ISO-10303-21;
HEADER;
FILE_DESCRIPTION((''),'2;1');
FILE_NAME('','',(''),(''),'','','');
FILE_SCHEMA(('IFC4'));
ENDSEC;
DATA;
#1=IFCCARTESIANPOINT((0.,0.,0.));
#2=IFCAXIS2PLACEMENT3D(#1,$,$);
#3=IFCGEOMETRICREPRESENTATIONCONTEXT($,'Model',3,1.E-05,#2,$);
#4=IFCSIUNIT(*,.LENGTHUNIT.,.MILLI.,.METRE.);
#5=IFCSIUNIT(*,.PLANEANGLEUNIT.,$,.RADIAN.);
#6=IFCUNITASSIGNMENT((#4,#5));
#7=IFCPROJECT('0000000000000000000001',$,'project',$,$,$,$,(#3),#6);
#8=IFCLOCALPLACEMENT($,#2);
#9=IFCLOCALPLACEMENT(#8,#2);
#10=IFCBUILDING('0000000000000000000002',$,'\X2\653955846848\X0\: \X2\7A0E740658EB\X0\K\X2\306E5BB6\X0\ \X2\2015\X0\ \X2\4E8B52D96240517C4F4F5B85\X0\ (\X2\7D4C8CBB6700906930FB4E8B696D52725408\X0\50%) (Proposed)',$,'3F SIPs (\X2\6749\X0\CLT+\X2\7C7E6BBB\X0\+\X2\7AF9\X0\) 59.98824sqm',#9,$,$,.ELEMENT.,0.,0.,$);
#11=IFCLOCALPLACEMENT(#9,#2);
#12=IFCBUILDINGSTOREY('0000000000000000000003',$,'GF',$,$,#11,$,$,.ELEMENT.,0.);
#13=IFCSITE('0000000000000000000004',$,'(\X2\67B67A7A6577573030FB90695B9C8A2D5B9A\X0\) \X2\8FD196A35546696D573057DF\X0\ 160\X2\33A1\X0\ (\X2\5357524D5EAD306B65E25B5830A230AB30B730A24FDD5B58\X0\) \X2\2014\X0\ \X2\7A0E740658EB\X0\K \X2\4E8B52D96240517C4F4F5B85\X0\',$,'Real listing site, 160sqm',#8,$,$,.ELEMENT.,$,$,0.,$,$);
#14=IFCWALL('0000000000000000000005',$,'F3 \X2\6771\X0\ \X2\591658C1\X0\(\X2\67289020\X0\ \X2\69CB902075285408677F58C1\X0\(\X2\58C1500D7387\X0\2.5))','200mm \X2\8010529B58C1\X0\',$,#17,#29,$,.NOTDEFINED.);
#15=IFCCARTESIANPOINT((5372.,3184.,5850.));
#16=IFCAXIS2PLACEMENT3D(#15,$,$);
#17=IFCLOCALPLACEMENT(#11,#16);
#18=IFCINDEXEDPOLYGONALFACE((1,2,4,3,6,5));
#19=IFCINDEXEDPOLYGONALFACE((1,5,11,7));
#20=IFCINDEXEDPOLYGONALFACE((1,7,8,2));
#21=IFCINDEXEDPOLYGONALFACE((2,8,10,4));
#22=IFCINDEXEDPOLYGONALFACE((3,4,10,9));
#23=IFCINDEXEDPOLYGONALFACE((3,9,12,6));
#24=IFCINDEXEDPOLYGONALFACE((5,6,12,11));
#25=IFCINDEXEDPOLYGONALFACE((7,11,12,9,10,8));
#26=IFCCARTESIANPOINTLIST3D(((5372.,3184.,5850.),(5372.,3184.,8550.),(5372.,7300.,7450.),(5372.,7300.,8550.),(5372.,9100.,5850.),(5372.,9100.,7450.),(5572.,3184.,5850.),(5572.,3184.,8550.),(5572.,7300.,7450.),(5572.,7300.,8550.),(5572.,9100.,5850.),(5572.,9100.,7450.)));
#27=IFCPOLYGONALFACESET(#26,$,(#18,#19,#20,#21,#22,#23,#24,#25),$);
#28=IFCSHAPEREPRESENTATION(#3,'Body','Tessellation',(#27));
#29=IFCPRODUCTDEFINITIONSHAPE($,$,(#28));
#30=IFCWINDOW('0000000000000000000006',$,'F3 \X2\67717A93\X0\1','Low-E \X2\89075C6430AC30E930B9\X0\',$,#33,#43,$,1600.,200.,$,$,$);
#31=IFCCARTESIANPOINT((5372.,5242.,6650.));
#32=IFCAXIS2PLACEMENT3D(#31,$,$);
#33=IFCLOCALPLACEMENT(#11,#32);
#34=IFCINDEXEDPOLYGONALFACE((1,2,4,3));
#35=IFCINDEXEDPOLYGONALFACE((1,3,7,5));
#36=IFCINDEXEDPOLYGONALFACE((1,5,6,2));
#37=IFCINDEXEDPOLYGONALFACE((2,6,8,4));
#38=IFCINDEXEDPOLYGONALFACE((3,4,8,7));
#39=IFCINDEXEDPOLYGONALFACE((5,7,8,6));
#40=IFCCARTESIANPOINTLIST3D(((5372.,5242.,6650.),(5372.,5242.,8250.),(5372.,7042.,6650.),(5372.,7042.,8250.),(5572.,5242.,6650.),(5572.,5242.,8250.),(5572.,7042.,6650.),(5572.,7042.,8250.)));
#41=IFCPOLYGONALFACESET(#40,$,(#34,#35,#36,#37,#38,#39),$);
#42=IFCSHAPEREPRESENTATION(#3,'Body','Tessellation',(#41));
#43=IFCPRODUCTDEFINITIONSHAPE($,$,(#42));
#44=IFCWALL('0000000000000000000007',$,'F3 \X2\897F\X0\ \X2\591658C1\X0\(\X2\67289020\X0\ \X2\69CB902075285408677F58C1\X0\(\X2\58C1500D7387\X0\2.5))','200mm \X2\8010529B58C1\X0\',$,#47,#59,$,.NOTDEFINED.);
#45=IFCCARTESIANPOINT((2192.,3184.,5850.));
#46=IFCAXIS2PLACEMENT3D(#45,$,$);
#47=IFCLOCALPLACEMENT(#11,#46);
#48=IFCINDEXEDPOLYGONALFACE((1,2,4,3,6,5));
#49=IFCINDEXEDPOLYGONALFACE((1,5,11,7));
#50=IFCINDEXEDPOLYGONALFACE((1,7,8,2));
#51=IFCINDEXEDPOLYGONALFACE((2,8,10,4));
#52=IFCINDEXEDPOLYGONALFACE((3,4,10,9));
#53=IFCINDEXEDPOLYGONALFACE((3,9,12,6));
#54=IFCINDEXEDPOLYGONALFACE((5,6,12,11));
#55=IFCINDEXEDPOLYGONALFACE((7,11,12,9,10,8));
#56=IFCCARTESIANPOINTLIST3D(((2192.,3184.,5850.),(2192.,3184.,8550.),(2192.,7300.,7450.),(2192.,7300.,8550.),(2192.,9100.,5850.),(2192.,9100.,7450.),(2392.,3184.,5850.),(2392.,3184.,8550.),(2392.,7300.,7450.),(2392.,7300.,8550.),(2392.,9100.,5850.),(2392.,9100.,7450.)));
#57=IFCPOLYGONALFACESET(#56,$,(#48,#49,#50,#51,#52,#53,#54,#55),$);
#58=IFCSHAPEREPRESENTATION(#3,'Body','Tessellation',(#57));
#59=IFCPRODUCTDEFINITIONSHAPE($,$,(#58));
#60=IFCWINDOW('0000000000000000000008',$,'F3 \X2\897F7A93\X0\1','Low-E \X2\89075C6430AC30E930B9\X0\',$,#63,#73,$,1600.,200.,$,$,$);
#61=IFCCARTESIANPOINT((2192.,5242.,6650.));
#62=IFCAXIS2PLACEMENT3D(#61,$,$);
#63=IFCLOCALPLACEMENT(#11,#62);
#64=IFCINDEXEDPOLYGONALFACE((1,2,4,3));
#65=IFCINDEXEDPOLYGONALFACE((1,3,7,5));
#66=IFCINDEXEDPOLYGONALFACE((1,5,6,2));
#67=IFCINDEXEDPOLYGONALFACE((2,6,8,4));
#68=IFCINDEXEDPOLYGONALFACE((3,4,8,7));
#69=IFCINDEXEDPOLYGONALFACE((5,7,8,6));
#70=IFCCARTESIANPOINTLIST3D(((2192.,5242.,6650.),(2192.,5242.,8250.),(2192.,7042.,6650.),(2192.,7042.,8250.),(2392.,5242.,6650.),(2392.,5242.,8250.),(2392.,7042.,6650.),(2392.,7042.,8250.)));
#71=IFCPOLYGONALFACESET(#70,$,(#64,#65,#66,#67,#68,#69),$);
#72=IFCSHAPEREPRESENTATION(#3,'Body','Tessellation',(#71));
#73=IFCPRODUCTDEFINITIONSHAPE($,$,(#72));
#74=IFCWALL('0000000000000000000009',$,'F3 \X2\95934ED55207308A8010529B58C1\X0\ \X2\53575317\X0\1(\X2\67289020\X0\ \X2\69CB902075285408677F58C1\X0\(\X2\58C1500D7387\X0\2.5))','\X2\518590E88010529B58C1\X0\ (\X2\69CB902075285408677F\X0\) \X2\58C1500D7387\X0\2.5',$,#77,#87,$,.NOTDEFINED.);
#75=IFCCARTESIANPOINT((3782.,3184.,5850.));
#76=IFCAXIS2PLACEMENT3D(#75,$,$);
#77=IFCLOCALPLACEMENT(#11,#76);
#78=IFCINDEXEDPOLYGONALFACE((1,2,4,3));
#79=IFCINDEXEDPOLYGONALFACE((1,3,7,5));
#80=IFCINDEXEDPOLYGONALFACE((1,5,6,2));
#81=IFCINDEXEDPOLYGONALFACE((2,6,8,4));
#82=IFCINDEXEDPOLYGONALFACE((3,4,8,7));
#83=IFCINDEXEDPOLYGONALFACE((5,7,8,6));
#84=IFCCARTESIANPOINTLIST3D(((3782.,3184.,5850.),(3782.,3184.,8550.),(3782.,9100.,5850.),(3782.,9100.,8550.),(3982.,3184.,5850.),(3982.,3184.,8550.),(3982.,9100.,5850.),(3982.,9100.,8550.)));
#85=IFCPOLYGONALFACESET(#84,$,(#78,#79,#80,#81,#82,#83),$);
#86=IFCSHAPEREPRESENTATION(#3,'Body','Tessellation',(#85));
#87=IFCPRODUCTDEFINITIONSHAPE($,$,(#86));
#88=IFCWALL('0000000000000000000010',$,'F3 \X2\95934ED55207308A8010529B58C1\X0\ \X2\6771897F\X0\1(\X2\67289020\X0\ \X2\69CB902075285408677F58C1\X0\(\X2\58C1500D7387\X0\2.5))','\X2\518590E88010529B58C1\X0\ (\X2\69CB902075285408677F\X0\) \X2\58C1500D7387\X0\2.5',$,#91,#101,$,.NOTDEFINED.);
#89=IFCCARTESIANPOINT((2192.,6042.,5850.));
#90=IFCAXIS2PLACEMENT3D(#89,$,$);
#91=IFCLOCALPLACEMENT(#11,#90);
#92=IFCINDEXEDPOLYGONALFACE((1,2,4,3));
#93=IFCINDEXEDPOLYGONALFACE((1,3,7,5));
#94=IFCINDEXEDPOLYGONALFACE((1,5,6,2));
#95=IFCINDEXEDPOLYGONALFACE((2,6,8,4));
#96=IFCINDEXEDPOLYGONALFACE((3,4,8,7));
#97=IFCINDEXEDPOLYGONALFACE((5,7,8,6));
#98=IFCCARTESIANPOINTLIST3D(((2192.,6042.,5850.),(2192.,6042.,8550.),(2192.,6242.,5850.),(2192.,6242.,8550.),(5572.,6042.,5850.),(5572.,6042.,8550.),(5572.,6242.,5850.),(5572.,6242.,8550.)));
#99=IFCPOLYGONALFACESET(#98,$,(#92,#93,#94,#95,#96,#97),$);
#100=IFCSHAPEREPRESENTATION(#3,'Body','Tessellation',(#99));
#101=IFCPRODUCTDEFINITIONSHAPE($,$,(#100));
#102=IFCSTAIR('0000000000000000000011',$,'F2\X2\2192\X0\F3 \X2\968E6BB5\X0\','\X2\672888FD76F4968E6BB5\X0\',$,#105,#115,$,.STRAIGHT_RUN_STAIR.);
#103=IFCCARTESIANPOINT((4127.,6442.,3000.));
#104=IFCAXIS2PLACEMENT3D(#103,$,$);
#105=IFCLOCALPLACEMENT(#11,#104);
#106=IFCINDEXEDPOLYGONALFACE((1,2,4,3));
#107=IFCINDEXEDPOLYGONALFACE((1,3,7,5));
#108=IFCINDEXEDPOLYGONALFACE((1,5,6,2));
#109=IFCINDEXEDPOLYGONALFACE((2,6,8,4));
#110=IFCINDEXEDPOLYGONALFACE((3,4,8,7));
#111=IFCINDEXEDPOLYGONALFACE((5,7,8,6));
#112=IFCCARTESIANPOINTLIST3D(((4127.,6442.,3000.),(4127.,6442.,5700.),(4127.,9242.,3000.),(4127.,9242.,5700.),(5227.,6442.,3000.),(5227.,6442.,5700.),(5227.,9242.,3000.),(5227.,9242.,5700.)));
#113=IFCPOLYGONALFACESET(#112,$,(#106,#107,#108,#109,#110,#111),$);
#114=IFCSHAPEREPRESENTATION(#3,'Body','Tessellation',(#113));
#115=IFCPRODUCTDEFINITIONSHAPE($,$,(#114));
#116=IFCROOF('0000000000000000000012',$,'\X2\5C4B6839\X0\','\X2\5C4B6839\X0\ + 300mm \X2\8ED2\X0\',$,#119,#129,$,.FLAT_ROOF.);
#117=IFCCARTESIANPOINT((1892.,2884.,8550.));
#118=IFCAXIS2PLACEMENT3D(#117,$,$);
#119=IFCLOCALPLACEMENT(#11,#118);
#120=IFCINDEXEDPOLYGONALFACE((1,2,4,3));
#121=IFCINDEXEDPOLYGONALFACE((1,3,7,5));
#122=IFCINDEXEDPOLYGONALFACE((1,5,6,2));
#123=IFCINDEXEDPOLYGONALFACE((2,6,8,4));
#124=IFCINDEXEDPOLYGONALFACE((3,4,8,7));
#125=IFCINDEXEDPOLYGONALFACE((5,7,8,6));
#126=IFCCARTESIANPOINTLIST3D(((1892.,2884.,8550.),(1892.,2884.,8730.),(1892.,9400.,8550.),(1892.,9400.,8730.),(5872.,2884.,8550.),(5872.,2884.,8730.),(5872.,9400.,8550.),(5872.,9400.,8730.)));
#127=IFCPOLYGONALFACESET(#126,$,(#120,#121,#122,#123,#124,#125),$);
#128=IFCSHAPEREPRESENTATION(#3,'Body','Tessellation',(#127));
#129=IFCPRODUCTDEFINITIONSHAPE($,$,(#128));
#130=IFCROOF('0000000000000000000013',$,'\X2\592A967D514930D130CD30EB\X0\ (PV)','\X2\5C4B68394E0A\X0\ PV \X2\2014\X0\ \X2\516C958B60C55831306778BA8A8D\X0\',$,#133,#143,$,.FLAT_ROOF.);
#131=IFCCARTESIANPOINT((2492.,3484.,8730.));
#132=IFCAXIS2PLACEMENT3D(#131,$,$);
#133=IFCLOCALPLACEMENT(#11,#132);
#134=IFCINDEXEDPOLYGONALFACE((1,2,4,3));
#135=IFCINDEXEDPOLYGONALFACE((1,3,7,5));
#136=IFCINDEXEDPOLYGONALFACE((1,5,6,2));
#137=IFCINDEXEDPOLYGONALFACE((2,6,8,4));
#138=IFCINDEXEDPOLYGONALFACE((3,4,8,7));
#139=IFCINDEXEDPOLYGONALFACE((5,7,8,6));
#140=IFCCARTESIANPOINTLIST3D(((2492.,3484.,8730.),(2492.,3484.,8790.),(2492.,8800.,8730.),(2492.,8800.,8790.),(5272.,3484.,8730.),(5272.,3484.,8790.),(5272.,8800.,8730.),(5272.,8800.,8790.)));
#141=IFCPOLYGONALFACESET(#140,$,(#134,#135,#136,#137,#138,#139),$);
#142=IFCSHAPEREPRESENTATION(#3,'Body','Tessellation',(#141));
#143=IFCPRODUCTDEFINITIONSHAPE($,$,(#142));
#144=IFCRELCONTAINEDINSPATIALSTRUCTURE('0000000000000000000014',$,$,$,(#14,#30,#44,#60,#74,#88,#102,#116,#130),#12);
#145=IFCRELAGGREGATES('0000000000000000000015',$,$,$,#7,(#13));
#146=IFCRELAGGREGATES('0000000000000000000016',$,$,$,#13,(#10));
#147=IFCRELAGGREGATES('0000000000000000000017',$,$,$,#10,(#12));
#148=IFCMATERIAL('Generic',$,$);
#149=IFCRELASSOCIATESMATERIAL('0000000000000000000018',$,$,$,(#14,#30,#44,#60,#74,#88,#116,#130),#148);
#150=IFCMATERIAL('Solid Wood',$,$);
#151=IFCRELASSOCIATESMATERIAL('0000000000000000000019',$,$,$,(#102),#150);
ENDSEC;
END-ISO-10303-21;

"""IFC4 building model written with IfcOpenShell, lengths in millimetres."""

from ifc_helpers import new_model, si_unit, frame, frame_2d, origin, place, context, project, spatial, rectangle, extrude, material, element, fill, save


model = new_model("IFC4")

# Units and contexts
model_context = context("Model", 3, precision=1e-05, world=origin())
ifc_project = project(units=[si_unit("LENGTHUNIT", "METRE", prefix="MILLI"), si_unit("PLANEANGLEUNIT", "RADIAN")], contexts=[model_context])

# Site, building, storey
site_placement = place(None, origin())
site = spatial("IfcSite", under=ifc_project, at=site_placement, Name="(架空敷地・適宜設定) 近隣商業地域 160㎡ (南前庭に既存アカシア保存) — 税理士K 事務所兼住宅", ObjectType="Real listing site, 160sqm", CompositionType="ELEMENT", RefElevation=0.0)
building_placement = place(site_placement, origin())
building = spatial("IfcBuilding", under=site, at=building_placement, Name="改善案: 税理士Kの家 ― 事務所兼住宅 (経費最適・事業割合50%) (Proposed)", ObjectType="3F SIPs (杉CLT+籾殻+竹) 59.98824sqm", CompositionType="ELEMENT", ElevationOfRefHeight=0.0, ElevationOfTerrain=0.0)
storey_placement = place(building_placement, origin())
storey = spatial("IfcBuildingStorey", under=building, at=storey_placement, Name="GF", CompositionType="ELEMENT", Elevation=0.0)

# Shared definitions
ifc_material_1 = material(Name="Generic")

# Walls, openings, windows
wall_1_placement = place(storey_placement, frame((5372.0, 3184.0, 5850.0)))
wall_1 = element("IfcWall", 1, at=wall_1_placement, inside=storey, material=ifc_material_1, Name="F3 東 外壁(木造 構造用合板壁(壁倍率2.5))", Description="200mm 耐力壁", PredefinedType="NOTDEFINED", context=model_context, shape_type="SweptSolid", body=[
    extrude(rectangle(XDim=200.0, YDim=5916.0, at=frame_2d((100.0, 2958.0))), frame((5372.0, 3184.0, 5850.0)), (0.0, 0.0, 1.0), 2700.0),
])
opening_1_placement = place(storey_placement, frame((5372.0, 5242.0, 6650.0)))
opening_1 = element("IfcOpeningElement", 2, at=opening_1_placement, cuts=wall_1, PredefinedType="NOTDEFINED", context=model_context, shape_type="SweptSolid", body=[
    extrude(rectangle(XDim=200.0, YDim=1800.0, at=frame_2d((100.0, 900.0))), frame((5372.0, 5242.0, 6650.0)), (0.0, 0.0, 1.0), 1600.0),
])
window_1_placement = place(storey_placement, frame((5372.0, 5242.0, 6650.0)))
window_1 = element("IfcWindow", 3, at=window_1_placement, inside=storey, material=ifc_material_1, Name="F3 東窓1", Description="Low-E 複層ガラス", OverallHeight=1600.0, OverallWidth=200.0, context=model_context, shape_type="SweptSolid", body=[
    extrude(rectangle(XDim=200.0, YDim=1800.0, at=frame_2d((100.0, 900.0))), frame((5372.0, 5242.0, 6650.0)), (0.0, 0.0, 1.0), 1600.0),
])
fill(opening_1, window_1)
wall_2_placement = place(storey_placement, frame((2192.0, 3184.0, 5850.0)))
wall_2 = element("IfcWall", 4, at=wall_2_placement, inside=storey, material=ifc_material_1, Name="F3 西 外壁(木造 構造用合板壁(壁倍率2.5))", Description="200mm 耐力壁", PredefinedType="NOTDEFINED", context=model_context, shape_type="SweptSolid", body=[
    extrude(rectangle(XDim=200.0, YDim=5916.0, at=frame_2d((100.0, 2958.0))), frame((2192.0, 3184.0, 5850.0)), (0.0, 0.0, 1.0), 2700.0),
])
opening_2_placement = place(storey_placement, frame((2192.0, 5242.0, 6650.0)))
opening_2 = element("IfcOpeningElement", 5, at=opening_2_placement, cuts=wall_2, PredefinedType="NOTDEFINED", context=model_context, shape_type="SweptSolid", body=[
    extrude(rectangle(XDim=200.0, YDim=1800.0, at=frame_2d((100.0, 900.0))), frame((2192.0, 5242.0, 6650.0)), (0.0, 0.0, 1.0), 1600.0),
])
window_2_placement = place(storey_placement, frame((2192.0, 5242.0, 6650.0)))
window_2 = element("IfcWindow", 6, at=window_2_placement, inside=storey, material=ifc_material_1, Name="F3 西窓1", Description="Low-E 複層ガラス", OverallHeight=1600.0, OverallWidth=200.0, context=model_context, shape_type="SweptSolid", body=[
    extrude(rectangle(XDim=200.0, YDim=1800.0, at=frame_2d((100.0, 900.0))), frame((2192.0, 5242.0, 6650.0)), (0.0, 0.0, 1.0), 1600.0),
])
fill(opening_2, window_2)

# Walls
wall_3_placement = place(storey_placement, frame((3782.0, 3184.0, 5850.0)))
element("IfcWall", 7, at=wall_3_placement, inside=storey, material=ifc_material_1, Name="F3 間仕切り耐力壁 南北1(木造 構造用合板壁(壁倍率2.5))", Description="内部耐力壁 (構造用合板) 壁倍率2.5", PredefinedType="NOTDEFINED", context=model_context, shape_type="SweptSolid", body=[
    extrude(rectangle(XDim=200.0, YDim=5916.0, at=frame_2d((100.0, 2958.0))), frame((3782.0, 3184.0, 5850.0)), (0.0, 0.0, 1.0), 2700.0),
])
wall_4_placement = place(storey_placement, frame((2192.0, 6042.0, 5850.0)))
element("IfcWall", 8, at=wall_4_placement, inside=storey, material=ifc_material_1, Name="F3 間仕切り耐力壁 東西1(木造 構造用合板壁(壁倍率2.5))", Description="内部耐力壁 (構造用合板) 壁倍率2.5", PredefinedType="NOTDEFINED", context=model_context, shape_type="SweptSolid", body=[
    extrude(rectangle(XDim=3380.0, YDim=200.0, at=frame_2d((1690.0, 100.0))), frame((2192.0, 6042.0, 5850.0)), (0.0, 0.0, 1.0), 2700.0),
])

# Stair
ifc_material_2 = material(Name="Solid Wood")
stair_placement = place(storey_placement, frame((4127.0, 6442.0, 3000.0)))
element("IfcStair", 9, at=stair_placement, inside=storey, material=ifc_material_2, Name="F2→F3 階段", Description="木製直階段", PredefinedType="STRAIGHT_RUN_STAIR", context=model_context, shape_type="SweptSolid", body=[
    extrude(rectangle(XDim=1100.0, YDim=2800.0, at=frame_2d((550.0, 1400.0))), frame((4127.0, 6442.0, 3000.0)), (0.0, 0.0, 1.0), 2700.0),
])

# Roofs
roof_1_placement = place(storey_placement, frame((1892.0, 2884.0, 8550.0)))
element("IfcRoof", 10, at=roof_1_placement, inside=storey, material=ifc_material_1, Name="屋根", Description="屋根 + 300mm 軒", PredefinedType="FLAT_ROOF", context=model_context, shape_type="SweptSolid", body=[
    extrude(rectangle(XDim=3980.0, YDim=6516.0, at=frame_2d((1990.0, 3258.0))), frame((1892.0, 2884.0, 8550.0)), (0.0, 0.0, 1.0), 180.0),
])
roof_2_placement = place(storey_placement, frame((2492.0, 3484.0, 8730.0)))
element("IfcRoof", 11, at=roof_2_placement, inside=storey, material=ifc_material_1, Name="太陽光パネル (PV)", Description="屋根上 PV — 公開情報で確認", PredefinedType="FLAT_ROOF", context=model_context, shape_type="SweptSolid", body=[
    extrude(rectangle(XDim=2780.0, YDim=5316.0, at=frame_2d((1390.0, 2658.0))), frame((2492.0, 3484.0, 8730.0)), (0.0, 0.0, 1.0), 60.0),
])

save(model, "model.ifc")
